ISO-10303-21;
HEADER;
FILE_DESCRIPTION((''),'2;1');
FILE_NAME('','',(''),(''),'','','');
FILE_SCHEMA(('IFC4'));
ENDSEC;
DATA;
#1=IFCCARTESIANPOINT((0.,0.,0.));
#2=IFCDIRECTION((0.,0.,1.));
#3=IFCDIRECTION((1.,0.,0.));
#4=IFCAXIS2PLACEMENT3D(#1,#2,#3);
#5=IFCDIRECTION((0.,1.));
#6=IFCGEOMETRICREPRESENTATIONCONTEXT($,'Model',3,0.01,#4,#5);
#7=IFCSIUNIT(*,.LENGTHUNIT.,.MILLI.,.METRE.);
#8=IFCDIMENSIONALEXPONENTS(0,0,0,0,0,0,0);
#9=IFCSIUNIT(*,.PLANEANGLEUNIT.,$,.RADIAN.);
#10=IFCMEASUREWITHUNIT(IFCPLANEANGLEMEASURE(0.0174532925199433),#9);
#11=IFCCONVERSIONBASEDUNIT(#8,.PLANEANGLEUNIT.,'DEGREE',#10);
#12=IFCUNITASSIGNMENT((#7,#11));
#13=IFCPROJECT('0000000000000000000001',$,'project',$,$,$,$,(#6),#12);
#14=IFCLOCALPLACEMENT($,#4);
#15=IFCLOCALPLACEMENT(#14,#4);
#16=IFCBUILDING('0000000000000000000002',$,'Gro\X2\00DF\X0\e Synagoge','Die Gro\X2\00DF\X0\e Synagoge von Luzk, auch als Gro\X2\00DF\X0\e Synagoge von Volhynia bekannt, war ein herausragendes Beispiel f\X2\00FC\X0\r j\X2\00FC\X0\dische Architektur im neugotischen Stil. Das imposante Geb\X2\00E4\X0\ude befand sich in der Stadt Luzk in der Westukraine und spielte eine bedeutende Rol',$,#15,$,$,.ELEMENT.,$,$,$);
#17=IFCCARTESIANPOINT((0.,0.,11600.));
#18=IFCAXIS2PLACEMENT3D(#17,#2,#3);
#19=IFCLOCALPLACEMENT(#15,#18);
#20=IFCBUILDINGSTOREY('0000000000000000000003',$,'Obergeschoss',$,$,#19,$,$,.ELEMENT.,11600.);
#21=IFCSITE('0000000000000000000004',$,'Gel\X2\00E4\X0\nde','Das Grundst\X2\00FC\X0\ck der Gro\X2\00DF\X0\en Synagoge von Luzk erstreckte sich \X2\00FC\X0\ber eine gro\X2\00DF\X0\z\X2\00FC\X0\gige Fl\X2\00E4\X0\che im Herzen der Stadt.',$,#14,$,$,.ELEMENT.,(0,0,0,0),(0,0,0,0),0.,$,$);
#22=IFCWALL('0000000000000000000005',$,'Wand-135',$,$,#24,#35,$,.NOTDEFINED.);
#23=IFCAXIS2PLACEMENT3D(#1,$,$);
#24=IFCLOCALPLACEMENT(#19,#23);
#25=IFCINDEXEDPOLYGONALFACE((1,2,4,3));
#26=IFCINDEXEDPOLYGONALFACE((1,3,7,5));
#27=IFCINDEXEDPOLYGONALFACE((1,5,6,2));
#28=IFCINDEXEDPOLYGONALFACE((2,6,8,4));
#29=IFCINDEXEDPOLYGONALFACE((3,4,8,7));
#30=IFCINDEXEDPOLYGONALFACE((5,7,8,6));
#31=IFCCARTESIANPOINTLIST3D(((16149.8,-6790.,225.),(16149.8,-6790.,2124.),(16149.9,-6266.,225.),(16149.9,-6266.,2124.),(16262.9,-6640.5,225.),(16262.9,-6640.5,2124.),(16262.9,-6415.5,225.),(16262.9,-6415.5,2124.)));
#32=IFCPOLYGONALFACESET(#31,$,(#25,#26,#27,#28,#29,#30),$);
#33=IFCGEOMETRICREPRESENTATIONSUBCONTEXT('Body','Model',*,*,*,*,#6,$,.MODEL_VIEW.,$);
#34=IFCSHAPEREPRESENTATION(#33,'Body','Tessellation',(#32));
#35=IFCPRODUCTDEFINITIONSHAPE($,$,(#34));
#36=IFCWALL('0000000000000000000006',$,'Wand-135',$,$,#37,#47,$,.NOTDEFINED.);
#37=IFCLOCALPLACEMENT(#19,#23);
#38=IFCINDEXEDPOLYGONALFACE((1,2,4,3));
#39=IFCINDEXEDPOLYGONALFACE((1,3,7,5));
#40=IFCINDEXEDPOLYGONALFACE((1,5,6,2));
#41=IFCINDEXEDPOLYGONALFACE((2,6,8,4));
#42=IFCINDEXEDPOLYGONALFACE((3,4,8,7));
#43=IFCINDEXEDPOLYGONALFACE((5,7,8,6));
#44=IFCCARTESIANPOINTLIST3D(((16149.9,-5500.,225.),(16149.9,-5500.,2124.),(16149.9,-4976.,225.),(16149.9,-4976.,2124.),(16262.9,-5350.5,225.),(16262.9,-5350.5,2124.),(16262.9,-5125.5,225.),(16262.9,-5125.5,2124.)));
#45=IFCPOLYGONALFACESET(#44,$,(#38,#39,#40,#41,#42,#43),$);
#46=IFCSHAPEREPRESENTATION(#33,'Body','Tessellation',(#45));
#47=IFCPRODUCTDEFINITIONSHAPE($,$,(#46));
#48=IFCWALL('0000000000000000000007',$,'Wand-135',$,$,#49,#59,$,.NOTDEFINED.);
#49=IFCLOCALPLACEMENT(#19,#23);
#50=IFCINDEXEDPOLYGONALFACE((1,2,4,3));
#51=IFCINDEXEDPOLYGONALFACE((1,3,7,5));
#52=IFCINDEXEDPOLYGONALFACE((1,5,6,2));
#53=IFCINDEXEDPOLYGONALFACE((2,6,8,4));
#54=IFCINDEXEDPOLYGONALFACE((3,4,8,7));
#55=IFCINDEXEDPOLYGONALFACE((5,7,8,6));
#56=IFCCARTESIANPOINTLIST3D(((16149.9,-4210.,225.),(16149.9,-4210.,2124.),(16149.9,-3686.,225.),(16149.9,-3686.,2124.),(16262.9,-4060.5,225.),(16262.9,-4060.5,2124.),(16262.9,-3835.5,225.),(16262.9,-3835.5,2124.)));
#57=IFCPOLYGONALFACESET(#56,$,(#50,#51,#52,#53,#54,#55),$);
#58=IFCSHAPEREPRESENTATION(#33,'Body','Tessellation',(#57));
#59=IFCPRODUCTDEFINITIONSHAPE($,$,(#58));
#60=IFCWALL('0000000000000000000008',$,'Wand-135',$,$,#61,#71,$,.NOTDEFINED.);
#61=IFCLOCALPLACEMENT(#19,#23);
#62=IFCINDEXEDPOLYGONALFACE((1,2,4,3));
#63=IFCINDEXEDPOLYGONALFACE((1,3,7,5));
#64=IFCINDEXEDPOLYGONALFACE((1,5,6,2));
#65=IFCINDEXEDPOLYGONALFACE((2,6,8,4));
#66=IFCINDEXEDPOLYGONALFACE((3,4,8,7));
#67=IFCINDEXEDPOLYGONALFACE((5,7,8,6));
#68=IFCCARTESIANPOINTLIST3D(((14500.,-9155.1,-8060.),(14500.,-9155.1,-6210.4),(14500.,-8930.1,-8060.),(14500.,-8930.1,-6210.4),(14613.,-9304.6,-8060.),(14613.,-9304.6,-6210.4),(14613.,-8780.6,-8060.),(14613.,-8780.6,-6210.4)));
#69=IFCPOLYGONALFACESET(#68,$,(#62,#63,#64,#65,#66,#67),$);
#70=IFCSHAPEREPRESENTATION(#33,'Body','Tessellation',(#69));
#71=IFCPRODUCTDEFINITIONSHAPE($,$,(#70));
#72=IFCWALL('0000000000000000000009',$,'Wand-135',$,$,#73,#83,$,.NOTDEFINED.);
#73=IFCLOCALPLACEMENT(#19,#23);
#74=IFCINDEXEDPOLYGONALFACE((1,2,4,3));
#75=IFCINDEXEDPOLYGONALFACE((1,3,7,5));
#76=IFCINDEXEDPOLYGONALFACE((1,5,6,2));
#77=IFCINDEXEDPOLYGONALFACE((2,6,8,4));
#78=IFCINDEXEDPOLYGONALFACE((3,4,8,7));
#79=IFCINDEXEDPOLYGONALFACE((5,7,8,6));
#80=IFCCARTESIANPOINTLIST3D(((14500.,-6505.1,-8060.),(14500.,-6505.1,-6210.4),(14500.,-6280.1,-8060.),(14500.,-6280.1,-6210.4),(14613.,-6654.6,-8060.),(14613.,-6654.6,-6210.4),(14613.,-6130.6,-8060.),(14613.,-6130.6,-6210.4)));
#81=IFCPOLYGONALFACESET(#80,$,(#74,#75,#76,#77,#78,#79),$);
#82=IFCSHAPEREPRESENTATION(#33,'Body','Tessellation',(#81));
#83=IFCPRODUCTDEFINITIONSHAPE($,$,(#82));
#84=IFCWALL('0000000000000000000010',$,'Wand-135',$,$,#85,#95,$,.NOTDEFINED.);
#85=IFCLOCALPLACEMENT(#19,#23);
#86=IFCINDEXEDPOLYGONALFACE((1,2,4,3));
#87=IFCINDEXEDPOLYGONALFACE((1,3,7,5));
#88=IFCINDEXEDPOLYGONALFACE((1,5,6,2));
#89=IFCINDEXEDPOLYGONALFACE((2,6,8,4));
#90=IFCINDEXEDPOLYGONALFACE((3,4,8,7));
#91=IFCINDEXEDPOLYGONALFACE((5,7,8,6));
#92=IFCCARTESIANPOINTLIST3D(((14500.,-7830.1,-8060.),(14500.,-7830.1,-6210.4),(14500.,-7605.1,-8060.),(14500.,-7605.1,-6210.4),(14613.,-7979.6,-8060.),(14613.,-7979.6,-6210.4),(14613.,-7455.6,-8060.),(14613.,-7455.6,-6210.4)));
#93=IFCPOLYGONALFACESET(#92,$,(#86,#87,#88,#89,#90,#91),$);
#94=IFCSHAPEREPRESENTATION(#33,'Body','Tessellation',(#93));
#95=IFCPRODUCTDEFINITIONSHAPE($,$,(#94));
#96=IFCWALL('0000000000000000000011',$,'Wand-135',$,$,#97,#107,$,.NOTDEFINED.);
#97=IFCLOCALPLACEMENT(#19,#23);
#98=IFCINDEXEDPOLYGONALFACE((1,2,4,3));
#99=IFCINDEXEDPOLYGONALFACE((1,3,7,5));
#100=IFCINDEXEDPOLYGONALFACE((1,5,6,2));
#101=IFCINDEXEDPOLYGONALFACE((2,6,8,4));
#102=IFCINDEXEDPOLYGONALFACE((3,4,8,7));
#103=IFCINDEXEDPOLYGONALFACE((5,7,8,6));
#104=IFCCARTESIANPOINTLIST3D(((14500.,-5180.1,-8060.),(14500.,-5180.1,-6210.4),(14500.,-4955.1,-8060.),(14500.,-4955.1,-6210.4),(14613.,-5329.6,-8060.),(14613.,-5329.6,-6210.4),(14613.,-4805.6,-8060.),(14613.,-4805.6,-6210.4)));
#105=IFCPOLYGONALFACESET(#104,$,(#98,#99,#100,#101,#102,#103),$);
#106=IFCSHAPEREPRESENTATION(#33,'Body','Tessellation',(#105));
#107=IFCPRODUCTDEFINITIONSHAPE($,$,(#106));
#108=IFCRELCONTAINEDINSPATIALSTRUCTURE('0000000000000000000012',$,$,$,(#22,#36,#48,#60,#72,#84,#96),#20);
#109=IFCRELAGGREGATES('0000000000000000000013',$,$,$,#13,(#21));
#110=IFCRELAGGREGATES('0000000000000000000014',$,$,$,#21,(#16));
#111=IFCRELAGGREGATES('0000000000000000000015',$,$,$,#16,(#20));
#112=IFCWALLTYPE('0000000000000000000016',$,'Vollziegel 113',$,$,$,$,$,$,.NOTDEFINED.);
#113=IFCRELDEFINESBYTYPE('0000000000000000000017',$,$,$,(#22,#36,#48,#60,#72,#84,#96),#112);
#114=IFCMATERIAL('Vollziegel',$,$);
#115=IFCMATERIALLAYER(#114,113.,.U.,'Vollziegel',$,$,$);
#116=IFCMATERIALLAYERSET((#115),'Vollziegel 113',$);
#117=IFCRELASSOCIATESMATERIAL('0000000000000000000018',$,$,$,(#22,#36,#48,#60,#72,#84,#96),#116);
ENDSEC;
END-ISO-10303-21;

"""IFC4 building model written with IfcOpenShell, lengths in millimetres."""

from ifc_helpers import new_model, entity, si_unit, converted_unit, direction, frame, origin_with_axes, place, context, subcontext, project, spatial, line, indexed_curve, outline, extrude, material, layer, layer_set, layer_usage, type_object, element, save


model = new_model("IFC4")

# Units and contexts
model_context = context("Model", 3, precision=0.01, world=origin_with_axes(), true_north=direction((0.0, 1.0)))
body_context = subcontext(model_context, "Body", "Model", "MODEL_VIEW")
ifc_project = project(units=[si_unit("LENGTHUNIT", "METRE", prefix="MILLI"), converted_unit("PLANEANGLEUNIT", "DEGREE", entity("IfcPlaneAngleMeasure", 0.0174532925199433), si_unit("PLANEANGLEUNIT", "RADIAN"), dimensions=[0, 0, 0, 0, 0, 0, 0])], contexts=[model_context])

# Site, building, storey
site_placement = place(None, origin_with_axes())
site = spatial("IfcSite", under=ifc_project, at=site_placement, Name="Gelände", Description="Das Grundstück der Großen Synagoge von Luzk erstreckte sich über eine großzügige Fläche im Herzen der Stadt.", CompositionType="ELEMENT", RefLatitude=(0, 0, 0, 0), RefLongitude=(0, 0, 0, 0), RefElevation=0.0)
building_placement = place(site_placement, origin_with_axes())
building = spatial("IfcBuilding", under=site, at=building_placement, Name="Große Synagoge", Description="Die Große Synagoge von Luzk, auch als Große Synagoge von Volhynia bekannt, war ein herausragendes Beispiel für jüdische Architektur im neugotischen Stil. Das imposante Gebäude befand sich in der Stadt Luzk in der Westukraine und spielte eine bedeutende Rol", CompositionType="ELEMENT")
storey_placement = place(building_placement, frame((0.0, 0.0, 11600.0), z_axis=(0.0, 0.0, 1.0), x_axis=(1.0, 0.0, 0.0)))
storey = spatial("IfcBuildingStorey", under=building, at=storey_placement, Name="Obergeschoss", CompositionType="ELEMENT", Elevation=11600.0)

# Walls
ifc_material_1 = material(Name="Vollziegel")
ifc_layer = layer(ifc_material_1, 113.0, ventilated="UNKNOWN", Name="Vollziegel")
ifc_layer_set = layer_set([ifc_layer], Name="Vollziegel 113")
wall_type_1 = type_object("IfcWallType", Name="Vollziegel 113", PredefinedType="NOTDEFINED")
ifc_layer_usage_1 = layer_usage(ifc_layer_set, "AXIS2", "NEGATIVE", 113.0)
wall_1_placement = place(storey_placement, frame((16149.9, -6415.5, 225.0), z_axis=(0.0, 0.0, 1.0), x_axis=(-0.000019, -1.0, 0.0)))
element("IfcWall", 1, at=wall_1_placement, inside=storey, type_object=wall_type_1, material=ifc_layer_usage_1, Name="Wand-135", PredefinedType="NOTDEFINED", context=body_context, shape_type="SweptSolid", body=[
    extrude(outline(indexed_curve([(-149.5, 0.0), (374.5, 0.0), (225.0, 113.0), (0.0, 113.0)], segments=[line(1, 2, 3, 4, 1)])), origin_with_axes(), (0.0, 0.0, 1.0), 1899.0),
])
ifc_layer_usage_2 = layer_usage(ifc_layer_set, "AXIS2", "NEGATIVE", 113.0)
wall_2_placement = place(storey_placement, frame((16149.9, -5125.5, 225.0), z_axis=(0.0, 0.0, 1.0), x_axis=(-0.000019, -1.0, 0.0)))
element("IfcWall", 2, at=wall_2_placement, inside=storey, type_object=wall_type_1, material=ifc_layer_usage_2, Name="Wand-135", PredefinedType="NOTDEFINED", context=body_context, shape_type="SweptSolid", body=[
    extrude(outline(indexed_curve([(-149.5, 0.0), (374.5, 0.0), (225.0, 113.0), (0.0, 113.0)], segments=[line(1, 2, 3, 4, 1)])), origin_with_axes(), (0.0, 0.0, 1.0), 1899.0),
])
ifc_layer_usage_3 = layer_usage(ifc_layer_set, "AXIS2", "NEGATIVE", 113.0)
wall_3_placement = place(storey_placement, frame((16149.9, -3835.5, 225.0), z_axis=(0.0, 0.0, 1.0), x_axis=(-0.000019, -1.0, 0.0)))
element("IfcWall", 3, at=wall_3_placement, inside=storey, type_object=wall_type_1, material=ifc_layer_usage_3, Name="Wand-135", PredefinedType="NOTDEFINED", context=body_context, shape_type="SweptSolid", body=[
    extrude(outline(indexed_curve([(-149.5, 0.0), (374.5, 0.0), (225.0, 113.0), (0.0, 113.0)], segments=[line(1, 2, 3, 4, 1)])), origin_with_axes(), (0.0, 0.0, 1.0), 1899.0),
])
ifc_layer_usage_4 = layer_usage(ifc_layer_set, "AXIS2", "POSITIVE", -113.0)
wall_4_placement = place(storey_placement, frame((14613.0, -8930.1, -8060.0), z_axis=(0.0, 0.0, 1.0), x_axis=(0.0, -1.0, 0.0)))
element("IfcWall", 4, at=wall_4_placement, inside=storey, type_object=wall_type_1, material=ifc_layer_usage_4, Name="Wand-135", PredefinedType="NOTDEFINED", context=body_context, shape_type="SweptSolid", body=[
    extrude(outline(indexed_curve([(0.0, -113.0), (225.0, -113.0), (374.5, 0.0), (-149.5, 0.0)], segments=[line(1, 2, 3, 4, 1)])), origin_with_axes(), (0.0, 0.0, 1.0), 1849.6),
])
ifc_layer_usage_5 = layer_usage(ifc_layer_set, "AXIS2", "POSITIVE", -113.0)
wall_5_placement = place(storey_placement, frame((14613.0, -6280.1, -8060.0), z_axis=(0.0, 0.0, 1.0), x_axis=(0.0, -1.0, 0.0)))
element("IfcWall", 5, at=wall_5_placement, inside=storey, type_object=wall_type_1, material=ifc_layer_usage_5, Name="Wand-135", PredefinedType="NOTDEFINED", context=body_context, shape_type="SweptSolid", body=[
    extrude(outline(indexed_curve([(0.0, -113.0), (225.0, -113.0), (374.5, 0.0), (-149.5, 0.0)], segments=[line(1, 2, 3, 4, 1)])), origin_with_axes(), (0.0, 0.0, 1.0), 1849.6),
])
ifc_layer_usage_6 = layer_usage(ifc_layer_set, "AXIS2", "POSITIVE", -113.0)
wall_6_placement = place(storey_placement, frame((14613.0, -7605.1, -8060.0), z_axis=(0.0, 0.0, 1.0), x_axis=(0.0, -1.0, 0.0)))
element("IfcWall", 6, at=wall_6_placement, inside=storey, type_object=wall_type_1, material=ifc_layer_usage_6, Name="Wand-135", PredefinedType="NOTDEFINED", context=body_context, shape_type="SweptSolid", body=[
    extrude(outline(indexed_curve([(0.0, -113.0), (225.0, -113.0), (374.5, 0.0), (-149.5, 0.0)], segments=[line(1, 2, 3, 4, 1)])), origin_with_axes(), (0.0, 0.0, 1.0), 1849.6),
])
ifc_layer_usage_7 = layer_usage(ifc_layer_set, "AXIS2", "POSITIVE", -113.0)
wall_7_placement = place(storey_placement, frame((14613.0, -4955.1, -8060.0), z_axis=(0.0, 0.0, 1.0), x_axis=(0.0, -1.0, 0.0)))
element("IfcWall", 7, at=wall_7_placement, inside=storey, type_object=wall_type_1, material=ifc_layer_usage_7, Name="Wand-135", PredefinedType="NOTDEFINED", context=body_context, shape_type="SweptSolid", body=[
    extrude(outline(indexed_curve([(0.0, -113.0), (225.0, -113.0), (374.5, 0.0), (-149.5, 0.0)], segments=[line(1, 2, 3, 4, 1)])), origin_with_axes(), (0.0, 0.0, 1.0), 1849.6),
])

save(model, "model.ifc")
